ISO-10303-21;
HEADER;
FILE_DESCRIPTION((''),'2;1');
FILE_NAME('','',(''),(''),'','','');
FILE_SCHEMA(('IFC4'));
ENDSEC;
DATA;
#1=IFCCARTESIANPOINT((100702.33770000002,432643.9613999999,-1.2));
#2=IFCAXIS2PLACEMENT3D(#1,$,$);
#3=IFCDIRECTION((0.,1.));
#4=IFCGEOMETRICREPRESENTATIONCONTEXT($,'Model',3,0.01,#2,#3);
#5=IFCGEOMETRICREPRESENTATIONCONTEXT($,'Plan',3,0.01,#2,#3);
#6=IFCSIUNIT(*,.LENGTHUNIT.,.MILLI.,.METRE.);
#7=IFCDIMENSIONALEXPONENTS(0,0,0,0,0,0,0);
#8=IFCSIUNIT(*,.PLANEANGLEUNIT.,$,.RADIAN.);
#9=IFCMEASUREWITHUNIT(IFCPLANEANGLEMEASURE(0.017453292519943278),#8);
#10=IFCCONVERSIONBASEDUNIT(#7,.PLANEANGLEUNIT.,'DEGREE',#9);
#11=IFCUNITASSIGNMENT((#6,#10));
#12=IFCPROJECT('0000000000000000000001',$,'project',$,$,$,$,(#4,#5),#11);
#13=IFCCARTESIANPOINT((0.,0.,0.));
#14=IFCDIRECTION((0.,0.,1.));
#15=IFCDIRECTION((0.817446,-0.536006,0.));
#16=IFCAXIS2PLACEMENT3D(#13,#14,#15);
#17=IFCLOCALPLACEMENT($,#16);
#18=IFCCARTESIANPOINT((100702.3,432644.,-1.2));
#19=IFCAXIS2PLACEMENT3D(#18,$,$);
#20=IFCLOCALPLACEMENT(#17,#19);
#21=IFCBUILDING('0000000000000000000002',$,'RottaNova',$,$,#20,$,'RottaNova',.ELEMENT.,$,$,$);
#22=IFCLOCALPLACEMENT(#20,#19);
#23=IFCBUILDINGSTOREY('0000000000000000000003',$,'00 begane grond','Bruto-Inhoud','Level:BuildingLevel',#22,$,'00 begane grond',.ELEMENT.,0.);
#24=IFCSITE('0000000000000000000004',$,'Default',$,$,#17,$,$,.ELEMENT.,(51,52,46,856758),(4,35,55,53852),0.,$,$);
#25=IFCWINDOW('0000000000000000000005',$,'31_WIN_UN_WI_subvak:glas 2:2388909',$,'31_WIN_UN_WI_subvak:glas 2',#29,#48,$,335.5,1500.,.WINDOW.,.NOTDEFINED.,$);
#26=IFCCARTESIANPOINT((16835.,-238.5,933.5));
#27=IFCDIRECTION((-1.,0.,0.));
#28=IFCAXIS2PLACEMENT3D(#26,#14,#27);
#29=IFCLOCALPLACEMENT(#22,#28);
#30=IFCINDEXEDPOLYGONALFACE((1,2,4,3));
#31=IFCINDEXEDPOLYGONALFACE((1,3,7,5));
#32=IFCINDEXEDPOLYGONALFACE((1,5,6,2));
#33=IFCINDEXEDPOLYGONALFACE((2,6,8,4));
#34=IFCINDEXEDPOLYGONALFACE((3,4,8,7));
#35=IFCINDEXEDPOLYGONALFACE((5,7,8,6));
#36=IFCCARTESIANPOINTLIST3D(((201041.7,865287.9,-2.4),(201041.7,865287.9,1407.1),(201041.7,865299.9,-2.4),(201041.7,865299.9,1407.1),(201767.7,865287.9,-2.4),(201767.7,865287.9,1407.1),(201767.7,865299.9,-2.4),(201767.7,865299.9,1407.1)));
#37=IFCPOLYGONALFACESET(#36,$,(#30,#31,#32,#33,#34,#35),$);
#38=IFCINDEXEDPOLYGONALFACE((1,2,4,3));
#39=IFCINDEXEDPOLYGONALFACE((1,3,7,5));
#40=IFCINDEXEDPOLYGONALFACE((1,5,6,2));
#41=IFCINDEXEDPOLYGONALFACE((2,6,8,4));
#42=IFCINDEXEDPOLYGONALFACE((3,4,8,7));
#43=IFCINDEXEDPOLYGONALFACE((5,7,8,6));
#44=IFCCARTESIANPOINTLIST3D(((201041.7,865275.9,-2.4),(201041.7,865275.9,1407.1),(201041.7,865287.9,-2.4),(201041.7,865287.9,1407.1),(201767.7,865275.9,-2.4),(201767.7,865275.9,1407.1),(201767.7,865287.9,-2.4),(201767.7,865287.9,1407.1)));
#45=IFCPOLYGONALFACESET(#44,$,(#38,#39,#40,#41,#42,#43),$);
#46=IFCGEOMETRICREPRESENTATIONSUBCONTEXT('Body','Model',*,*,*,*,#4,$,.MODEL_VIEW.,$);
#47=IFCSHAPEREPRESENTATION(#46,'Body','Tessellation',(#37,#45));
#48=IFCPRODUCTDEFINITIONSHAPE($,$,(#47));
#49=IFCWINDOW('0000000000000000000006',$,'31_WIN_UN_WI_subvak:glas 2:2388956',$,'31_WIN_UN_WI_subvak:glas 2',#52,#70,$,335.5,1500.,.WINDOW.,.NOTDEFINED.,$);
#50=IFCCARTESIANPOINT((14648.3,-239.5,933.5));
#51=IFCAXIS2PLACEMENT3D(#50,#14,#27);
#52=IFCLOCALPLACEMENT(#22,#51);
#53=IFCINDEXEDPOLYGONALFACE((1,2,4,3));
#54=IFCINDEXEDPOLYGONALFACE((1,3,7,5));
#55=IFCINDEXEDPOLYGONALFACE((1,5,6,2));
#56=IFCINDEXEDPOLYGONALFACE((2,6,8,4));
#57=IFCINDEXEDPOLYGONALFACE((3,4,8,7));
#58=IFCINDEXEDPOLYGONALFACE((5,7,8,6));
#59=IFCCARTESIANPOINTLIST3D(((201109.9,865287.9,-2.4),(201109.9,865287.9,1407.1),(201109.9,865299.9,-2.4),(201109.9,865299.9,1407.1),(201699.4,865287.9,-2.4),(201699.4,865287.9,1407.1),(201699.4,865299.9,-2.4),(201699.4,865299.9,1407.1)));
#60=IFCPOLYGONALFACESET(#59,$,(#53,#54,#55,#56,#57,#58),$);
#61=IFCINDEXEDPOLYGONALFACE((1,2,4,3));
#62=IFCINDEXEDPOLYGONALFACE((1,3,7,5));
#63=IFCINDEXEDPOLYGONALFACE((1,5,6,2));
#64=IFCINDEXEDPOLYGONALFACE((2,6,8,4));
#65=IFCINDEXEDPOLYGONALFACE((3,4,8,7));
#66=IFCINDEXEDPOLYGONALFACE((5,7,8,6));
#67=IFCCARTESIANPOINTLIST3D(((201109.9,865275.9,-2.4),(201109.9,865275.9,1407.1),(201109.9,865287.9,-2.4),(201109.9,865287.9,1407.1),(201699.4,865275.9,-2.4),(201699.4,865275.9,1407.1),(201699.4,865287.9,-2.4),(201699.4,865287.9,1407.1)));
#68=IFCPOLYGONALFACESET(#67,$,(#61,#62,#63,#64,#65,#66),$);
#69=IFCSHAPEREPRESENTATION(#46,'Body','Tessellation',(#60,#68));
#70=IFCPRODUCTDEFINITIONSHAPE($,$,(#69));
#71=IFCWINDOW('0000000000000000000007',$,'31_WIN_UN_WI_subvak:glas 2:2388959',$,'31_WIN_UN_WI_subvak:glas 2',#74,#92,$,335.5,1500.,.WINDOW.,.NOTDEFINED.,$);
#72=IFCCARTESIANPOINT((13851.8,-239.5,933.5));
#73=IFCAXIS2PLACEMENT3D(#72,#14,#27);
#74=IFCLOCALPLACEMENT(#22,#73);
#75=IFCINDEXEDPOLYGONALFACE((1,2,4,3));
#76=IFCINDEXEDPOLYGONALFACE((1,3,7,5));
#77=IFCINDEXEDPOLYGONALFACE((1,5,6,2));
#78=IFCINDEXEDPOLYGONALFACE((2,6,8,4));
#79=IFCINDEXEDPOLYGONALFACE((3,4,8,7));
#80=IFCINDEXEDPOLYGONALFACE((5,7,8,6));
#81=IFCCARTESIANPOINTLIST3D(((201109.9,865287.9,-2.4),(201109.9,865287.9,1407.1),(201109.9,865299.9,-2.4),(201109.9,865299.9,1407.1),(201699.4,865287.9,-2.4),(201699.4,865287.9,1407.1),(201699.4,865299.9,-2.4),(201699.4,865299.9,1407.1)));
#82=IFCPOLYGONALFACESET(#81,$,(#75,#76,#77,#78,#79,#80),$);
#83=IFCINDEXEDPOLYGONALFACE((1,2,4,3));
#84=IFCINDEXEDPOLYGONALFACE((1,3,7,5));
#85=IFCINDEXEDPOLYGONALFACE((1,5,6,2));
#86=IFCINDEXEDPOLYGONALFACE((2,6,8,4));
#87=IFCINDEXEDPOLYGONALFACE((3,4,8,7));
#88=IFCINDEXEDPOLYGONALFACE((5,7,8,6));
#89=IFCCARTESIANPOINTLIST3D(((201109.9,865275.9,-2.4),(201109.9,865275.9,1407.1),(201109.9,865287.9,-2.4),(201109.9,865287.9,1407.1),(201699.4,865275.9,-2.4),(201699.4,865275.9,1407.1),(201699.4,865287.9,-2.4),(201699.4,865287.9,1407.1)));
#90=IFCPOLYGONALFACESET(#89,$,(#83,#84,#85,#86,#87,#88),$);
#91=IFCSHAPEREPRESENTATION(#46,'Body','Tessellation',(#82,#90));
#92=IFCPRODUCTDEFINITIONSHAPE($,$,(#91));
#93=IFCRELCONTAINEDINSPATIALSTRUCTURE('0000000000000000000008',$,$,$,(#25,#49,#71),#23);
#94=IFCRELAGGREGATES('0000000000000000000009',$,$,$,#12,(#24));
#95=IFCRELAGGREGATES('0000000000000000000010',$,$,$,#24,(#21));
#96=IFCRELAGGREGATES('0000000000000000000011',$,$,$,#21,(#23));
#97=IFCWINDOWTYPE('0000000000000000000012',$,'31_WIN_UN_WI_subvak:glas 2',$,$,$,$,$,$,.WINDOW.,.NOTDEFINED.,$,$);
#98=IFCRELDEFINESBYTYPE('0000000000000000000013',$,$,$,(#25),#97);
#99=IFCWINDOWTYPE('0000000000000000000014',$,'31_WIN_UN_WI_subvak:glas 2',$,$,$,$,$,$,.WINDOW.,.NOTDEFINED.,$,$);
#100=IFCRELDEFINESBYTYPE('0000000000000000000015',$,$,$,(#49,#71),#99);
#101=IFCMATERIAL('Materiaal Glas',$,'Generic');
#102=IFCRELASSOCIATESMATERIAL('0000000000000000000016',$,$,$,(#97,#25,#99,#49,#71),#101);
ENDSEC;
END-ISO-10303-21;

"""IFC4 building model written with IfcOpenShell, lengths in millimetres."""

from ifc_helpers import new_model, entity, si_unit, converted_unit, direction, frame, place, context, subcontext, project, spatial, indexed_curve, outline, extrude, source, transform, mapped, material, type_object, type_shapes, element, save


model = new_model("IFC4")

# Units and contexts
model_context = context("Model", 3, precision=0.01, world=frame((100702.33770000002, 432643.9613999999, -1.2)), true_north=direction((0.0, 1.0)))
plan_context = context("Plan", 3, precision=0.01, world=frame((100702.33770000002, 432643.9613999999, -1.2)), true_north=direction((0.0, 1.0)))
body_context = subcontext(model_context, "Body", "Model", "MODEL_VIEW")
ifc_project = project(units=[si_unit("LENGTHUNIT", "METRE", prefix="MILLI"), converted_unit("PLANEANGLEUNIT", "DEGREE", entity("IfcPlaneAngleMeasure", 0.017453292519943278), si_unit("PLANEANGLEUNIT", "RADIAN"), dimensions=[0, 0, 0, 0, 0, 0, 0])], contexts=[model_context, plan_context])

# Site, building, storey
site_placement = place(None, frame((0.0, 0.0, 0.0), z_axis=(0.0, 0.0, 1.0), x_axis=(0.817446, -0.536006, 0.0)))
site = spatial("IfcSite", under=ifc_project, at=site_placement, Name="Default", CompositionType="ELEMENT", RefLatitude=(51, 52, 46, 856758), RefLongitude=(4, 35, 55, 53852), RefElevation=0.0)
building_placement = place(site_placement, frame((100702.3, 432644.0, -1.2)))
building = spatial("IfcBuilding", under=site, at=building_placement, Name="RottaNova", LongName="RottaNova", CompositionType="ELEMENT")
storey_placement = place(building_placement, frame((100702.3, 432644.0, -1.2)))
storey = spatial("IfcBuildingStorey", under=building, at=storey_placement, Name="00 begane grond", Description="Bruto-Inhoud", ObjectType="Level:BuildingLevel", LongName="00 begane grond", CompositionType="ELEMENT", Elevation=0.0)

# Windows
ifc_material_1 = material(Name="Materiaal Glas", Category="Generic")
window_type_1 = type_object("IfcWindowType", Name="31_WIN_UN_WI_subvak:glas 2", PartitioningType="NOTDEFINED", PredefinedType="WINDOW", material=ifc_material_1)
shared_shape_1 = source(frame((100702.3, 432644.0, -1.2)), body_context, "Body", "SweptSolid", [
    extrude(outline(indexed_curve([(-6.0, -363.0), (6.0, -363.0), (6.0, 363.0), (-6.0, 363.0), (-6.0, -363.0)], self_intersect=False)), frame((0.0, 6.0, 0.0), z_axis=(0.0, 0.0, 1.0), x_axis=(0.0, -1.0, 0.0)), (0.0, 0.0, 1.0), 1409.5),
    extrude(outline(indexed_curve([(-6.0, -363.0), (6.0, -363.0), (6.0, 363.0), (-6.0, 363.0), (-6.0, -363.0)], self_intersect=False)), frame((0.0, -6.0, 0.0), z_axis=(0.0, 0.0, 1.0), x_axis=(0.0, -1.0, 0.0)), (0.0, 0.0, 1.0), 1409.5),
])
type_shapes(window_type_1, [shared_shape_1])
window_1_placement = place(storey_placement, frame((16835.0, -238.5, 933.5), z_axis=(0.0, 0.0, 1.0), x_axis=(-1.0, 0.0, 0.0)))
element("IfcWindow", 1, at=window_1_placement, inside=storey, type_object=window_type_1, material=ifc_material_1, Name="31_WIN_UN_WI_subvak:glas 2:2388909", ObjectType="31_WIN_UN_WI_subvak:glas 2", OverallHeight=335.5, OverallWidth=1500.0, PartitioningType="NOTDEFINED", PredefinedType="WINDOW", context=body_context, shape_type="MappedRepresentation", body=[
    mapped(shared_shape_1, transform((100702.3, 432644.0, -1.2), scale=1.0)),
])
window_type_2 = type_object("IfcWindowType", Name="31_WIN_UN_WI_subvak:glas 2", PartitioningType="NOTDEFINED", PredefinedType="WINDOW", material=ifc_material_1)
shared_shape_2 = source(frame((100702.3, 432644.0, -1.2)), body_context, "Body", "SweptSolid", [
    extrude(outline(indexed_curve([(-6.0, -294.7), (6.0, -294.7), (6.0, 294.7), (-6.0, 294.7), (-6.0, -294.7)], self_intersect=False)), frame((0.0, 6.0, 0.0), z_axis=(0.0, 0.0, 1.0), x_axis=(0.0, -1.0, 0.0)), (0.0, 0.0, 1.0), 1409.5),
    extrude(outline(indexed_curve([(-6.0, -294.8), (6.0, -294.8), (6.0, 294.8), (-6.0, 294.8), (-6.0, -294.8)], self_intersect=False)), frame((0.0, -6.0, 0.0), z_axis=(0.0, 0.0, 1.0), x_axis=(0.0, -1.0, 0.0)), (0.0, 0.0, 1.0), 1409.5),
])
type_shapes(window_type_2, [shared_shape_2])
for number, where, z_axis, x_axis, name in (
    (2, (14648.3, -239.5, 933.5), (0.0, 0.0, 1.0), (-1.0, 0.0, 0.0), "31_WIN_UN_WI_subvak:glas 2:2388956"),
    (3, (13851.8, -239.5, 933.5), (0.0, 0.0, 1.0), (-1.0, 0.0, 0.0), "31_WIN_UN_WI_subvak:glas 2:2388959"),
):
    element("IfcWindow", number, at=place(storey_placement, frame(where, z_axis=z_axis, x_axis=x_axis)), inside=storey, type_object=window_type_2, material=ifc_material_1, Name=name, ObjectType="31_WIN_UN_WI_subvak:glas 2", OverallHeight=335.5, OverallWidth=1500.0, PartitioningType="NOTDEFINED", PredefinedType="WINDOW", context=body_context, shape_type="MappedRepresentation", body=[
        mapped(shared_shape_2, transform((100702.3, 432644.0, -1.2), scale=1.0)),
    ])

save(model, "model.ifc")
